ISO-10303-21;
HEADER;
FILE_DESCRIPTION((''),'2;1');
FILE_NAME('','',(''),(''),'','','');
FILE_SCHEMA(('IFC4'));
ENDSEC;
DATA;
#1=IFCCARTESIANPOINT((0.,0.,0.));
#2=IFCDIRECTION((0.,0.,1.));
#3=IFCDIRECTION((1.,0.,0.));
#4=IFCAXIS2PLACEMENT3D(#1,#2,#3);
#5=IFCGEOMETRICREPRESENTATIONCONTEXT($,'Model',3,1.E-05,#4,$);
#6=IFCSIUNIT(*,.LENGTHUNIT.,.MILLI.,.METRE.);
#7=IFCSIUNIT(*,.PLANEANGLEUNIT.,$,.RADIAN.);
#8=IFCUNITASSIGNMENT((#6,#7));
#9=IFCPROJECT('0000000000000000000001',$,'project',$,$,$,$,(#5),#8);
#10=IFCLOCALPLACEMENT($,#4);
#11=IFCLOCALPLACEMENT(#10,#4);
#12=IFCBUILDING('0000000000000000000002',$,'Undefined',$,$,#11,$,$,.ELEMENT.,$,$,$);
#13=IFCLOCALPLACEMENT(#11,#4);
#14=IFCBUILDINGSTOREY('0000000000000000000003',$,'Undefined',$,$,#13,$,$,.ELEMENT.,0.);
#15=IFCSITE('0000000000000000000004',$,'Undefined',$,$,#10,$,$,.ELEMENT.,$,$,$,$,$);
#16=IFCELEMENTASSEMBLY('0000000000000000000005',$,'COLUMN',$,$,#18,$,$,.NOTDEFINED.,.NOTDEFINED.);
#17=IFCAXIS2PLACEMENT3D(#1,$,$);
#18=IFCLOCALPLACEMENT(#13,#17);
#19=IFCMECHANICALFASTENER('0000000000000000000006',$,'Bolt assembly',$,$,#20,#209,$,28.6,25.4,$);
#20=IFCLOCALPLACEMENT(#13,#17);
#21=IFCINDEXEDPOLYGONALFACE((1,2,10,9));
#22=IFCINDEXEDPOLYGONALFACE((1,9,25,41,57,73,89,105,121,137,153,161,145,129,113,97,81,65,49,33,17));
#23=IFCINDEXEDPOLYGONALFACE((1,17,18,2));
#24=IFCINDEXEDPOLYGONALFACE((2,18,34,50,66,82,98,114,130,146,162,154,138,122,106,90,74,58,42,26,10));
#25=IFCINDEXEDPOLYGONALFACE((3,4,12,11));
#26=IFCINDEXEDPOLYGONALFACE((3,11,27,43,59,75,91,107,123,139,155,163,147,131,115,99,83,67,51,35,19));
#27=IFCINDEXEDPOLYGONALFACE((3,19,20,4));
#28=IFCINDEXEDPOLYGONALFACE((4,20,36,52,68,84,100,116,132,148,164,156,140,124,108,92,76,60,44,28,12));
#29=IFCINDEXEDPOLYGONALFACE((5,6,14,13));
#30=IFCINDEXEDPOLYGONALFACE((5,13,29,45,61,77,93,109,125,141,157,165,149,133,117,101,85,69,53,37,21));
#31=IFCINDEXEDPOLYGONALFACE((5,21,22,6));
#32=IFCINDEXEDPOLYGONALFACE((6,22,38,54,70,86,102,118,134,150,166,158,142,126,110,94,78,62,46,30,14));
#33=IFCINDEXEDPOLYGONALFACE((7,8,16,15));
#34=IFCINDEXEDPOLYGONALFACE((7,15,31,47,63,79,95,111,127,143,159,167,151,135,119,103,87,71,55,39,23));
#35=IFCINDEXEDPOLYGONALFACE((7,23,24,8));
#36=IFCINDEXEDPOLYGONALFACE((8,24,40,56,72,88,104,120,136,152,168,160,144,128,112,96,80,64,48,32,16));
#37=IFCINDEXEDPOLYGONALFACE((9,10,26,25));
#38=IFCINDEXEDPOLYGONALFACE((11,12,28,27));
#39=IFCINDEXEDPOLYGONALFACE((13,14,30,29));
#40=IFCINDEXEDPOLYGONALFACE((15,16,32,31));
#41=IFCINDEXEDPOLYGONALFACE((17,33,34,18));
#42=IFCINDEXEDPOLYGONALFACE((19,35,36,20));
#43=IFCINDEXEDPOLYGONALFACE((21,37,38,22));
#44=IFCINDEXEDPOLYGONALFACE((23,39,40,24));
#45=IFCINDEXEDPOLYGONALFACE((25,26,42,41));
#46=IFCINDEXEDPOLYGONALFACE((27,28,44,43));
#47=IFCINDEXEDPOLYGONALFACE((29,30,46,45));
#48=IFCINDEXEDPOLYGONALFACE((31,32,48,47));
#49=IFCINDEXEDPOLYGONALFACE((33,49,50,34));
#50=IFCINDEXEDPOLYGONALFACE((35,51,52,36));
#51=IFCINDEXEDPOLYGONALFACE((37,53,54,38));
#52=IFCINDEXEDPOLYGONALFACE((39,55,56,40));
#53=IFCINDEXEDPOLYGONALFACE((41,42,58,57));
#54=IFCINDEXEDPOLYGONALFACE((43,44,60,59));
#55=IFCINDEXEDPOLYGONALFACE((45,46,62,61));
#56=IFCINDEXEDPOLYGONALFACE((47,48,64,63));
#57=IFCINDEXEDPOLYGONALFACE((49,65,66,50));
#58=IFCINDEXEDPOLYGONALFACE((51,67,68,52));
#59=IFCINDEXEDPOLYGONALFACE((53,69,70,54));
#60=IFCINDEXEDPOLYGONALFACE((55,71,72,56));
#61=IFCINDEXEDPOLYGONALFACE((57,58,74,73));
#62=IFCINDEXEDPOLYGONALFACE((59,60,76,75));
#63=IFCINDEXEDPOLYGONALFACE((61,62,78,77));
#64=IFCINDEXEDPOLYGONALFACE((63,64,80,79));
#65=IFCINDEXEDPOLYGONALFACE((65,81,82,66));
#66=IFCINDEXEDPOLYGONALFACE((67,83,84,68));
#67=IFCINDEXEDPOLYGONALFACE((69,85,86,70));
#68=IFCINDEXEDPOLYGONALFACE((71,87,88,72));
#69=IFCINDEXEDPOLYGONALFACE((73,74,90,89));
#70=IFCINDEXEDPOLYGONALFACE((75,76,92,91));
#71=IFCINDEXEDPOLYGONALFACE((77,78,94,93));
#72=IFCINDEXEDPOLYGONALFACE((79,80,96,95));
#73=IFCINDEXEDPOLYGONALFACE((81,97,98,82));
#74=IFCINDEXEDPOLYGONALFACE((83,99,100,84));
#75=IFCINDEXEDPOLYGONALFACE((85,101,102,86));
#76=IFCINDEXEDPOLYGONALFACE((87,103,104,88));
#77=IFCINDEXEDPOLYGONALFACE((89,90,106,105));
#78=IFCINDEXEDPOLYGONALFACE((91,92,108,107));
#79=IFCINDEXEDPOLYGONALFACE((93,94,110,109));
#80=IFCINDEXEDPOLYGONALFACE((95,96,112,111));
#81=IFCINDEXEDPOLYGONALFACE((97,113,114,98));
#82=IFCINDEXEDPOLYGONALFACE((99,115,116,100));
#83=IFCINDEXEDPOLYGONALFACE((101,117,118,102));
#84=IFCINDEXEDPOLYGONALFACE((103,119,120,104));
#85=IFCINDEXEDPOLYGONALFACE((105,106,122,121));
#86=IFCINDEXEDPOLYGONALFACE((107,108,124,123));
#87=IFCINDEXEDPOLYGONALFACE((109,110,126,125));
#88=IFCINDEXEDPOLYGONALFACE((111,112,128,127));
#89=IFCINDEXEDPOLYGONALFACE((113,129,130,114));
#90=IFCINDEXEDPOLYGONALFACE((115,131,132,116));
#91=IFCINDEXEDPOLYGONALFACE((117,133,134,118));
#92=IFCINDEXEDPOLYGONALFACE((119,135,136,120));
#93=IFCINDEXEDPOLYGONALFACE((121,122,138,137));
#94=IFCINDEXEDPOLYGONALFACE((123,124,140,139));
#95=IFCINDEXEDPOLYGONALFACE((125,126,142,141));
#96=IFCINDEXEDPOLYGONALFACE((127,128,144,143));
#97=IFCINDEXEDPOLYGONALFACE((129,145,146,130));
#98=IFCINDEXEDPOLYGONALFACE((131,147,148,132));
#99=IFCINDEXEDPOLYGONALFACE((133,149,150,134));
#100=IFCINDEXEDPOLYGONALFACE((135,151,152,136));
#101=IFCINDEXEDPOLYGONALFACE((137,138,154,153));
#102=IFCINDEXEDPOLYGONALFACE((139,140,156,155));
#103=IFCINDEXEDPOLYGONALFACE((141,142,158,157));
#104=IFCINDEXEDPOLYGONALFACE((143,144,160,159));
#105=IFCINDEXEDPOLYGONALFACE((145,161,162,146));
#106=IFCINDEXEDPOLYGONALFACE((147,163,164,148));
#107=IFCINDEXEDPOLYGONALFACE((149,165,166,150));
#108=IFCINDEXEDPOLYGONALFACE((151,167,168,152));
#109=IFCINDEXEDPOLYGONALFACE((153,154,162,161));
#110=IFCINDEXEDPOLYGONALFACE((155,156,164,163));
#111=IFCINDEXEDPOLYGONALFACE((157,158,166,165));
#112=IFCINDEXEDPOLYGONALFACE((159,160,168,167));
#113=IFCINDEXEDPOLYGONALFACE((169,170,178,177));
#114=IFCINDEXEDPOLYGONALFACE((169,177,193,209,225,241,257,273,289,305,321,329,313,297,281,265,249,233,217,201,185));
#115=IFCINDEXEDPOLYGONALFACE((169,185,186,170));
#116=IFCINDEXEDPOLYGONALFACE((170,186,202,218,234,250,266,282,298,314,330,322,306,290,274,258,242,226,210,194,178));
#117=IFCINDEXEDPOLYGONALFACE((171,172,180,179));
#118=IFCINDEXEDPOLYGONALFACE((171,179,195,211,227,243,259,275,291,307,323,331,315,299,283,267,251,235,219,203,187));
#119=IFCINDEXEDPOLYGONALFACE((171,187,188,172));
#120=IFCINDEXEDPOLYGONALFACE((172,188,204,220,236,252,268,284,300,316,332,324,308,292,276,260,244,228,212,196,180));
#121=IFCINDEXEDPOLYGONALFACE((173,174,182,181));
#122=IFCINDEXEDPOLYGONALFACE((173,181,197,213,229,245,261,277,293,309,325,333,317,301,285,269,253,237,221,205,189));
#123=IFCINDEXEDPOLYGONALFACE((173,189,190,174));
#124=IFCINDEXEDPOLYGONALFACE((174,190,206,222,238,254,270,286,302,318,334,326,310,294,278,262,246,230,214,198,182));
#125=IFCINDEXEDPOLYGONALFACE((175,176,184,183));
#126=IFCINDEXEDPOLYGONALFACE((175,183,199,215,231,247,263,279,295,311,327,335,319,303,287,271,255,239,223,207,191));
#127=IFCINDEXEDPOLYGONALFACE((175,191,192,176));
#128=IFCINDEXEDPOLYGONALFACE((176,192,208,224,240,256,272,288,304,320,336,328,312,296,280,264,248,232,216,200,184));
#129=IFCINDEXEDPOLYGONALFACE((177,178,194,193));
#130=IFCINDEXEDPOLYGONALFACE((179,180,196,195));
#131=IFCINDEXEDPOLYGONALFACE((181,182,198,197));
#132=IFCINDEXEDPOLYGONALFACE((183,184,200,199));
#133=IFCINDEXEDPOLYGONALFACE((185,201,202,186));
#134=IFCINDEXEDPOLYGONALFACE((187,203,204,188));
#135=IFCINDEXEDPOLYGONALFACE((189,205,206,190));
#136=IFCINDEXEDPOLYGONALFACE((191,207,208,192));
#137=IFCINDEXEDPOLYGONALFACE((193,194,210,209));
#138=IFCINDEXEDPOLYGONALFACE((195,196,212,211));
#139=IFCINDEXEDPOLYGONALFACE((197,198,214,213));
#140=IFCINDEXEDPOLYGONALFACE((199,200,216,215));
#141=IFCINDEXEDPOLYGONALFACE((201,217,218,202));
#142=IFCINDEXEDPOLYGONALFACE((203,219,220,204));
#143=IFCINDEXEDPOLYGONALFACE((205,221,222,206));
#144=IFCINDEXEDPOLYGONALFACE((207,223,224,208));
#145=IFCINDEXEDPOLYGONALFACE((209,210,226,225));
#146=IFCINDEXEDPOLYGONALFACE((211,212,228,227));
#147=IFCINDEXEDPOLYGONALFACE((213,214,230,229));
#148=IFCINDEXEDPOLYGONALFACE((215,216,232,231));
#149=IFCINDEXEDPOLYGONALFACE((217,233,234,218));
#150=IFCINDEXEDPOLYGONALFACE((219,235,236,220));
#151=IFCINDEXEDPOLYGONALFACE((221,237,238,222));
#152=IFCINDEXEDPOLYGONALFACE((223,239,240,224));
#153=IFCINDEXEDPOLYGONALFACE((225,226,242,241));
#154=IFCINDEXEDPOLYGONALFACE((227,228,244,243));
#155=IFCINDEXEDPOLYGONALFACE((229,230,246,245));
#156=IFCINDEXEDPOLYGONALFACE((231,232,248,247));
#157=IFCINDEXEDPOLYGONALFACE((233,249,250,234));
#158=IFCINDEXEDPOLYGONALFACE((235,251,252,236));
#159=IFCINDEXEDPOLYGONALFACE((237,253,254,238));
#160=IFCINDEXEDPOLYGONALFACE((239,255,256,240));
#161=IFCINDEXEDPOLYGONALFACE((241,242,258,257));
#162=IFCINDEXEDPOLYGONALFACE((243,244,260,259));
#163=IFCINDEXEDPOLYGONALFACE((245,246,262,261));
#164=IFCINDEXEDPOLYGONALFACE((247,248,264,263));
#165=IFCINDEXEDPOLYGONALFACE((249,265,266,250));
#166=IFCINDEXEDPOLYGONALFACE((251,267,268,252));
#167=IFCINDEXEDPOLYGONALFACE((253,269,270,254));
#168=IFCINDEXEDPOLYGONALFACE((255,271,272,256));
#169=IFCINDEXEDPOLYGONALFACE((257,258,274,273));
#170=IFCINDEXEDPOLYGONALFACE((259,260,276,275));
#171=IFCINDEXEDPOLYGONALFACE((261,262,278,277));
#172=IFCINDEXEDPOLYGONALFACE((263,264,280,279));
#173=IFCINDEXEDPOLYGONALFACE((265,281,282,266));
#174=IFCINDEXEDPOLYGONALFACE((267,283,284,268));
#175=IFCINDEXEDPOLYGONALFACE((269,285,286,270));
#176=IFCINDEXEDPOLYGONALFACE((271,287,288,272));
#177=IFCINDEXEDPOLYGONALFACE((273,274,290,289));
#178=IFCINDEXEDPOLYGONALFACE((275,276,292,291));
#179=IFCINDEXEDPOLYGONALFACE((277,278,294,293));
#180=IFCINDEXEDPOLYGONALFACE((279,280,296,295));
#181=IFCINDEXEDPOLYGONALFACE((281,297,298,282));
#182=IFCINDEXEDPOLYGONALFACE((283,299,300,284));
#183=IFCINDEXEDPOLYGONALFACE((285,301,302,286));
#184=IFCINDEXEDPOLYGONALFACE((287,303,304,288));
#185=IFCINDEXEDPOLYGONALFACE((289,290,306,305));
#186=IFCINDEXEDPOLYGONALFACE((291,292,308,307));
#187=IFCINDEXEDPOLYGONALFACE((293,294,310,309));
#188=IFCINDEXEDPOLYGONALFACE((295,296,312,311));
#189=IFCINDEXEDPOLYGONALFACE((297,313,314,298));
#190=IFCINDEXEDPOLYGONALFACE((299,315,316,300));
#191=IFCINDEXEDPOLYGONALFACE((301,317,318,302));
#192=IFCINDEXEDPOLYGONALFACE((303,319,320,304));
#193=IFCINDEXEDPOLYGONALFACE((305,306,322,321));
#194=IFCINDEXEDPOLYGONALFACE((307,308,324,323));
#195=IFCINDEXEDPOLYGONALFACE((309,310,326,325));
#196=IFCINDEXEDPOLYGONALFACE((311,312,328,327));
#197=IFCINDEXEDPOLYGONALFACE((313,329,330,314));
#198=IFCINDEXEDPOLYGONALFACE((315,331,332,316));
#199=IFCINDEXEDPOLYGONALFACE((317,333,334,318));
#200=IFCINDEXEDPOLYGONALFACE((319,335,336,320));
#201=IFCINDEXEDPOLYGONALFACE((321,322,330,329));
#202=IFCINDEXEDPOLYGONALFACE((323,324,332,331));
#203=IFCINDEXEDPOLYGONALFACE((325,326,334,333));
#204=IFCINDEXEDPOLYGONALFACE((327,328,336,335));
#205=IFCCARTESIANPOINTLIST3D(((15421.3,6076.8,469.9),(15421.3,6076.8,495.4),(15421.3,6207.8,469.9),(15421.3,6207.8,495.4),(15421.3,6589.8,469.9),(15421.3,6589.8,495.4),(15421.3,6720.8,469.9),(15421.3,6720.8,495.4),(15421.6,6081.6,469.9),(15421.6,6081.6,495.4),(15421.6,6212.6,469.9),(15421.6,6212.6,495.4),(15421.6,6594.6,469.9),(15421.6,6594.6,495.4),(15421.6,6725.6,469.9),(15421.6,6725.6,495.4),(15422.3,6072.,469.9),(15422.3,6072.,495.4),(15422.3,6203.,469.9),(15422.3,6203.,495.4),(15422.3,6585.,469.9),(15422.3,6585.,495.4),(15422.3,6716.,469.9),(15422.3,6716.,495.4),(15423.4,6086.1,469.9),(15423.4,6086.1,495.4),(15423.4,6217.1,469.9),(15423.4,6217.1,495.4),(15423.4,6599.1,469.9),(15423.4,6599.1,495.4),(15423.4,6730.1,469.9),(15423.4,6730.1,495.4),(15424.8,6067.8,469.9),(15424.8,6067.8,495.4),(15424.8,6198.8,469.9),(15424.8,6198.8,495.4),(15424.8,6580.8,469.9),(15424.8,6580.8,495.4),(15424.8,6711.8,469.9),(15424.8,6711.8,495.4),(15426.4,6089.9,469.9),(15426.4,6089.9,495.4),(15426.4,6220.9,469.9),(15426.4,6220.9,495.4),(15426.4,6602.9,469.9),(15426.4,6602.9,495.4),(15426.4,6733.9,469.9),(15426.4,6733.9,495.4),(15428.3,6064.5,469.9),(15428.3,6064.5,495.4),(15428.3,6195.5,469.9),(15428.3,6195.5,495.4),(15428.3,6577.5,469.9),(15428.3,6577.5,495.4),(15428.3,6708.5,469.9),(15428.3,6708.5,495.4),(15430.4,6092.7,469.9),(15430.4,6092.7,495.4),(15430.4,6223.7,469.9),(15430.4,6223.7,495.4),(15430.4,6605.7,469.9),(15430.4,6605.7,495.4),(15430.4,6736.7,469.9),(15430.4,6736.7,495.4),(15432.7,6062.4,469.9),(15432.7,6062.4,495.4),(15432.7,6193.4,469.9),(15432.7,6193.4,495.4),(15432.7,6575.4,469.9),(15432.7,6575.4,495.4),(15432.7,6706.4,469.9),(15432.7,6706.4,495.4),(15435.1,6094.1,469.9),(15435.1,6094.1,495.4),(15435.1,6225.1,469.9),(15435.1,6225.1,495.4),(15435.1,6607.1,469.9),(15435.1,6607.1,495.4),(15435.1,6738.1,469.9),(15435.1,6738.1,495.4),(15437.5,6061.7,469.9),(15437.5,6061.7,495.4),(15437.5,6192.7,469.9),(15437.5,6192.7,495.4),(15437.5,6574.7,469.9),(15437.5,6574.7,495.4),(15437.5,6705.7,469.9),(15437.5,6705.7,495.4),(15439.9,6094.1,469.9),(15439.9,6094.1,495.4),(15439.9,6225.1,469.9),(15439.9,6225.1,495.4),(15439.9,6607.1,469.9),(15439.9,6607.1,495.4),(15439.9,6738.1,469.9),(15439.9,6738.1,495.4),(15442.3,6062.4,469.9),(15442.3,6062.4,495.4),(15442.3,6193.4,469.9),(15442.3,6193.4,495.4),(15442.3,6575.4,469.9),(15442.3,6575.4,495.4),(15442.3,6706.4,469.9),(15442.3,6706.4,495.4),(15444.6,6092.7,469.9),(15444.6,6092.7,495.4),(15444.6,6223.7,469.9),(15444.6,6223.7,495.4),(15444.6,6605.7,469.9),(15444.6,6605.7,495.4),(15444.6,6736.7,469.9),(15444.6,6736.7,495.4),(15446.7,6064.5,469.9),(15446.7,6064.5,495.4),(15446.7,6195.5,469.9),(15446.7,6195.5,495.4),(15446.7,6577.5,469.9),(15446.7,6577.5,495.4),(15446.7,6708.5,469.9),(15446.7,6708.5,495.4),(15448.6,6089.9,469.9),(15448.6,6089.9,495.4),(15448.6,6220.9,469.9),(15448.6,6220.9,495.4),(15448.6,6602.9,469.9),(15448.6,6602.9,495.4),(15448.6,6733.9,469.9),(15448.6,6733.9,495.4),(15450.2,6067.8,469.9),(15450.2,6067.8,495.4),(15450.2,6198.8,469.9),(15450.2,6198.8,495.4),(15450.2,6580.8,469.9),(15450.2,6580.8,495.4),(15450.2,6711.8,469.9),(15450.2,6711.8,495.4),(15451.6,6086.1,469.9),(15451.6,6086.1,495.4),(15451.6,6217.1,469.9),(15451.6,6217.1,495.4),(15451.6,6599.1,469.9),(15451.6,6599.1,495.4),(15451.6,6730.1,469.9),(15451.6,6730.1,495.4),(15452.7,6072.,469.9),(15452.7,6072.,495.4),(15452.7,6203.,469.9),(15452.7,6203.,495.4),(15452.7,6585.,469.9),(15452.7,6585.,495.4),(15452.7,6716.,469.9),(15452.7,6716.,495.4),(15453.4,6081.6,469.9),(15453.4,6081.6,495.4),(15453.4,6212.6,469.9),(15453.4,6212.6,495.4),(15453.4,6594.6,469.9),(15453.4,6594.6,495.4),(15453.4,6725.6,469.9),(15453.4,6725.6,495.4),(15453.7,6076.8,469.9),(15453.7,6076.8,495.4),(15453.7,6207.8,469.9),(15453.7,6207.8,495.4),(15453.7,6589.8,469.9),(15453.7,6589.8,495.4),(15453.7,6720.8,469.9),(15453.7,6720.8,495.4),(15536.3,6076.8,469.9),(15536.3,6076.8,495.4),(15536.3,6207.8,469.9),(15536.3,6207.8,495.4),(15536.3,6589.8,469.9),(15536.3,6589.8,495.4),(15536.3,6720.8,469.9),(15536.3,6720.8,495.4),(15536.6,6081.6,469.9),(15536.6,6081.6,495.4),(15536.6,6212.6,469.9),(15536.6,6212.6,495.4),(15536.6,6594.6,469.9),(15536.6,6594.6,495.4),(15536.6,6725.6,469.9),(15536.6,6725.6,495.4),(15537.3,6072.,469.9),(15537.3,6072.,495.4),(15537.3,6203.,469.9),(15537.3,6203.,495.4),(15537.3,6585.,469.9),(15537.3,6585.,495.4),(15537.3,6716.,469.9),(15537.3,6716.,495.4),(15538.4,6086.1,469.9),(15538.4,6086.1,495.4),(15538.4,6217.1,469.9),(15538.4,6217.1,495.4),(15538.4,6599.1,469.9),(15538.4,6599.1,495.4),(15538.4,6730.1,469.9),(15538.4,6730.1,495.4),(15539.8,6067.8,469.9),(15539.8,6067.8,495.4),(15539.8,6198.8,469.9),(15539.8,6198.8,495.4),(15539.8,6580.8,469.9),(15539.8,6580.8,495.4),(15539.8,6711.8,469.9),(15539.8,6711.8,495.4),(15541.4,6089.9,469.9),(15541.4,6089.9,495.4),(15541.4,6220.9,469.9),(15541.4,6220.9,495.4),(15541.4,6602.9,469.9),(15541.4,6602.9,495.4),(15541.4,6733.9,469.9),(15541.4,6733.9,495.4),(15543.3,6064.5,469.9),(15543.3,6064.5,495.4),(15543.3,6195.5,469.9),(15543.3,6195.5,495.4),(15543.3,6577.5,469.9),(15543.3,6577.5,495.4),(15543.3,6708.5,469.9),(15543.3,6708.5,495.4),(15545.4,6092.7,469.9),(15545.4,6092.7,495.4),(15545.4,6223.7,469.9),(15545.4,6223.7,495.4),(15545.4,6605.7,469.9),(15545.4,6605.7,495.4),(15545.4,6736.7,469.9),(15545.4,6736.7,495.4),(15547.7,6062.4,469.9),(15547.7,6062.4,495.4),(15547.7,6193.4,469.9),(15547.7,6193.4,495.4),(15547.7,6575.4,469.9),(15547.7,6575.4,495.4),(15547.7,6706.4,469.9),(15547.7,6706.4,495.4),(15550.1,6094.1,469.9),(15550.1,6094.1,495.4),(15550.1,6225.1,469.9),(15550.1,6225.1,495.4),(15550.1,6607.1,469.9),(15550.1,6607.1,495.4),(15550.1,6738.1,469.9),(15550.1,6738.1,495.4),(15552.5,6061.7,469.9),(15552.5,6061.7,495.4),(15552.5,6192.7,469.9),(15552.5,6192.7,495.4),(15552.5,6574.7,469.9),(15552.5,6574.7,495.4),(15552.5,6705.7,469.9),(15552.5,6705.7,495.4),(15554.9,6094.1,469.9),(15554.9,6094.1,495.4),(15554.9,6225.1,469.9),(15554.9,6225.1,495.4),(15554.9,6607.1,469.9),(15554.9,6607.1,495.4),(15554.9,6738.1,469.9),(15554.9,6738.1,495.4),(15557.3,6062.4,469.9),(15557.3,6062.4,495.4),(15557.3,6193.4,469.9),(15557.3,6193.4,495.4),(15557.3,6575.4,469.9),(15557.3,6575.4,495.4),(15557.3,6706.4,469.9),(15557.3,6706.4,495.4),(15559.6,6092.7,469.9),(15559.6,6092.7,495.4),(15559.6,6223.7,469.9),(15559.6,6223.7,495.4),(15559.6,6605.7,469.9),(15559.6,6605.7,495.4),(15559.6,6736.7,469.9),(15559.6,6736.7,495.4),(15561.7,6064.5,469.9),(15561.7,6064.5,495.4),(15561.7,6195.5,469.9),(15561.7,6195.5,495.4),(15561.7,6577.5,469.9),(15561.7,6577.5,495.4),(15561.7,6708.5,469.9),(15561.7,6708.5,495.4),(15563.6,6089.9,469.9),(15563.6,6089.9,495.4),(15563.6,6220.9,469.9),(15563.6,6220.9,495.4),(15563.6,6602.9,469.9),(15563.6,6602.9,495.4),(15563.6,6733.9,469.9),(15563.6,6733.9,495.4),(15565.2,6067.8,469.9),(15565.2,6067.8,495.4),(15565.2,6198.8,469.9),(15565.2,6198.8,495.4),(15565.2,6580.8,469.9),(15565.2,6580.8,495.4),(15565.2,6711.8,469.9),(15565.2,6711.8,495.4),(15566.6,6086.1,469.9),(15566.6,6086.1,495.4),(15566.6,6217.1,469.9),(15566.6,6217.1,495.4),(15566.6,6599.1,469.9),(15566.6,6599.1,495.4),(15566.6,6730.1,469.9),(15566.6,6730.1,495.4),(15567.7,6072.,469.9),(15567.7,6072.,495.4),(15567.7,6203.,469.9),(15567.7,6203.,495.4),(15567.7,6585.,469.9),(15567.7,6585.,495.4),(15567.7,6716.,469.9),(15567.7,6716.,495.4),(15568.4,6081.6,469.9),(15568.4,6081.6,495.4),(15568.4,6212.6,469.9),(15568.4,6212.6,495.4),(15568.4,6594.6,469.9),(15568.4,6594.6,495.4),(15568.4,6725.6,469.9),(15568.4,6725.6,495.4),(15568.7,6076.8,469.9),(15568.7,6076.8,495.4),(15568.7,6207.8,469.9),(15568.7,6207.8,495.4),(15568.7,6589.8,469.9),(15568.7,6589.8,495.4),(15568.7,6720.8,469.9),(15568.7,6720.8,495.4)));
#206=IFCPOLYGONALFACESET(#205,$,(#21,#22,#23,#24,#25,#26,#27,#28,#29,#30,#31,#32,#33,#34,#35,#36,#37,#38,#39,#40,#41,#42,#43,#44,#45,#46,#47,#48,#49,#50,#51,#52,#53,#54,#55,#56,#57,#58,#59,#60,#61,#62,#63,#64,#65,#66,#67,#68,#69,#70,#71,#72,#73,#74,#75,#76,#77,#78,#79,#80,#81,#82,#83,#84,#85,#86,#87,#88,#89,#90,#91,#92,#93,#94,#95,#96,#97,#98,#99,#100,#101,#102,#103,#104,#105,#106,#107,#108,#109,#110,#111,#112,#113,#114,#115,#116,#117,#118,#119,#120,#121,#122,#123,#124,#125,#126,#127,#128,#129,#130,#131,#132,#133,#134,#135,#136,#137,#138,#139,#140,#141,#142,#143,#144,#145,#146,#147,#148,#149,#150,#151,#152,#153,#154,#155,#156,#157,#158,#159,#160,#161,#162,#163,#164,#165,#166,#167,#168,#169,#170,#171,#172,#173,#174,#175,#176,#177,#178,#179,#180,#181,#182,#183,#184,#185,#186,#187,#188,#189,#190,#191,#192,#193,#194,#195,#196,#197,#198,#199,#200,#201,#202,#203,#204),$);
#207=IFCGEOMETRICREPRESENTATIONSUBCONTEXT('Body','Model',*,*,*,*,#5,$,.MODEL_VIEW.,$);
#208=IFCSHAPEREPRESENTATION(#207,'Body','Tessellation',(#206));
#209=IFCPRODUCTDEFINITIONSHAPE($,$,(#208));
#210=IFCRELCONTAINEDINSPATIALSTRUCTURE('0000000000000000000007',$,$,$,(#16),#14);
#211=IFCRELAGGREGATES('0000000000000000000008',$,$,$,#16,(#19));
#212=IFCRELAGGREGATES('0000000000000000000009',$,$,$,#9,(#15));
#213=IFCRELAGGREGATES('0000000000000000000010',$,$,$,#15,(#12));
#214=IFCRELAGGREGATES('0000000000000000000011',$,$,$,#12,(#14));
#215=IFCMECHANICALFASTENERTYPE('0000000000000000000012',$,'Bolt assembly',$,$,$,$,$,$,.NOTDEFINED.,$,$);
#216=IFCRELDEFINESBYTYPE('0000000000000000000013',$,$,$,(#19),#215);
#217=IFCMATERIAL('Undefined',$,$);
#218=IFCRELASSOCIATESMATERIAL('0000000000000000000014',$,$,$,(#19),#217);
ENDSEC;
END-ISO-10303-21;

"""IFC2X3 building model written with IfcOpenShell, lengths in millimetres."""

from ifc_helpers import new_model, si_unit, frame, origin_with_axes, origin_2d_with_axis, place, context, subcontext, project, spatial, circle, extrude, source, transform, mapped, material, type_object, element, aggregate, save


model = new_model("IFC2X3")

# Units and contexts
model_context = context("Model", 3, precision=1e-05, world=origin_with_axes())
body_context = subcontext(model_context, "Body", "Model", "MODEL_VIEW")
ifc_project = project(units=[si_unit("LENGTHUNIT", "METRE", prefix="MILLI"), si_unit("PLANEANGLEUNIT", "RADIAN")], contexts=[model_context])

# Site, building, storey
site_placement = place(None, origin_with_axes())
site = spatial("IfcSite", under=ifc_project, at=site_placement, Name="Undefined", CompositionType="ELEMENT")
building_placement = place(site_placement, origin_with_axes())
building = spatial("IfcBuilding", under=site, at=building_placement, Name="Undefined", CompositionType="ELEMENT")
storey_placement = place(building_placement, origin_with_axes())
storey = spatial("IfcBuildingStorey", under=building, at=storey_placement, Name="Undefined", CompositionType="ELEMENT", Elevation=0.0)

# Element assembly
assembly_1_placement = place(storey_placement, origin_with_axes())
assembly_1 = element("IfcElementAssembly", 1, at=assembly_1_placement, inside=storey, Name="COLUMN", AssemblyPlace="NOTDEFINED", PredefinedType="NOTDEFINED")

# Shared definitions
ifc_material_1 = material(Name="Undefined")
mechanical_fastener_type = type_object("IfcMechanicalFastenerType", Name="Bolt assembly")

# Mechanical fastener
shared_shape_1 = source(origin_with_axes(), body_context, "Body", "SweptSolid", [
    extrude(circle(Radius=16.3, at=origin_2d_with_axis()), frame((0.0, 0.0, 0.0), z_axis=(0.0, 1.0, 0.0), x_axis=(1.0, 0.0, 0.0)), (0.0, 0.0, 1.0), 25.5),
])
mechanical_fastener_1_placement = place(assembly_1_placement, frame((15495.0, 6661.9, 495.4), z_axis=(1.0, 0.0, 0.0), x_axis=(0.0, -1.0, 0.0)))
mechanical_fastener_1 = element("IfcMechanicalFastener", 2, at=mechanical_fastener_1_placement, type_object=mechanical_fastener_type, material=ifc_material_1, Name="Bolt assembly", NominalDiameter=28.6, NominalLength=25.4, context=body_context, shape_type="MappedRepresentation", body=[
    mapped(shared_shape_1, transform((-60.1, 0.0, -57.5))),
    mapped(shared_shape_1, transform((-60.1, 0.0, 57.5))),
    mapped(shared_shape_1, transform((70.9, 0.0, -57.5))),
    mapped(shared_shape_1, transform((70.9, 0.0, 57.5))),
    mapped(shared_shape_1, transform((452.9, 0.0, -57.5))),
    mapped(shared_shape_1, transform((452.9, 0.0, 57.5))),
    mapped(shared_shape_1, transform((583.9, 0.0, -57.5))),
    mapped(shared_shape_1, transform((583.9, 0.0, 57.5))),
])
aggregate(assembly_1, [mechanical_fastener_1])

save(model, "model.ifc")
